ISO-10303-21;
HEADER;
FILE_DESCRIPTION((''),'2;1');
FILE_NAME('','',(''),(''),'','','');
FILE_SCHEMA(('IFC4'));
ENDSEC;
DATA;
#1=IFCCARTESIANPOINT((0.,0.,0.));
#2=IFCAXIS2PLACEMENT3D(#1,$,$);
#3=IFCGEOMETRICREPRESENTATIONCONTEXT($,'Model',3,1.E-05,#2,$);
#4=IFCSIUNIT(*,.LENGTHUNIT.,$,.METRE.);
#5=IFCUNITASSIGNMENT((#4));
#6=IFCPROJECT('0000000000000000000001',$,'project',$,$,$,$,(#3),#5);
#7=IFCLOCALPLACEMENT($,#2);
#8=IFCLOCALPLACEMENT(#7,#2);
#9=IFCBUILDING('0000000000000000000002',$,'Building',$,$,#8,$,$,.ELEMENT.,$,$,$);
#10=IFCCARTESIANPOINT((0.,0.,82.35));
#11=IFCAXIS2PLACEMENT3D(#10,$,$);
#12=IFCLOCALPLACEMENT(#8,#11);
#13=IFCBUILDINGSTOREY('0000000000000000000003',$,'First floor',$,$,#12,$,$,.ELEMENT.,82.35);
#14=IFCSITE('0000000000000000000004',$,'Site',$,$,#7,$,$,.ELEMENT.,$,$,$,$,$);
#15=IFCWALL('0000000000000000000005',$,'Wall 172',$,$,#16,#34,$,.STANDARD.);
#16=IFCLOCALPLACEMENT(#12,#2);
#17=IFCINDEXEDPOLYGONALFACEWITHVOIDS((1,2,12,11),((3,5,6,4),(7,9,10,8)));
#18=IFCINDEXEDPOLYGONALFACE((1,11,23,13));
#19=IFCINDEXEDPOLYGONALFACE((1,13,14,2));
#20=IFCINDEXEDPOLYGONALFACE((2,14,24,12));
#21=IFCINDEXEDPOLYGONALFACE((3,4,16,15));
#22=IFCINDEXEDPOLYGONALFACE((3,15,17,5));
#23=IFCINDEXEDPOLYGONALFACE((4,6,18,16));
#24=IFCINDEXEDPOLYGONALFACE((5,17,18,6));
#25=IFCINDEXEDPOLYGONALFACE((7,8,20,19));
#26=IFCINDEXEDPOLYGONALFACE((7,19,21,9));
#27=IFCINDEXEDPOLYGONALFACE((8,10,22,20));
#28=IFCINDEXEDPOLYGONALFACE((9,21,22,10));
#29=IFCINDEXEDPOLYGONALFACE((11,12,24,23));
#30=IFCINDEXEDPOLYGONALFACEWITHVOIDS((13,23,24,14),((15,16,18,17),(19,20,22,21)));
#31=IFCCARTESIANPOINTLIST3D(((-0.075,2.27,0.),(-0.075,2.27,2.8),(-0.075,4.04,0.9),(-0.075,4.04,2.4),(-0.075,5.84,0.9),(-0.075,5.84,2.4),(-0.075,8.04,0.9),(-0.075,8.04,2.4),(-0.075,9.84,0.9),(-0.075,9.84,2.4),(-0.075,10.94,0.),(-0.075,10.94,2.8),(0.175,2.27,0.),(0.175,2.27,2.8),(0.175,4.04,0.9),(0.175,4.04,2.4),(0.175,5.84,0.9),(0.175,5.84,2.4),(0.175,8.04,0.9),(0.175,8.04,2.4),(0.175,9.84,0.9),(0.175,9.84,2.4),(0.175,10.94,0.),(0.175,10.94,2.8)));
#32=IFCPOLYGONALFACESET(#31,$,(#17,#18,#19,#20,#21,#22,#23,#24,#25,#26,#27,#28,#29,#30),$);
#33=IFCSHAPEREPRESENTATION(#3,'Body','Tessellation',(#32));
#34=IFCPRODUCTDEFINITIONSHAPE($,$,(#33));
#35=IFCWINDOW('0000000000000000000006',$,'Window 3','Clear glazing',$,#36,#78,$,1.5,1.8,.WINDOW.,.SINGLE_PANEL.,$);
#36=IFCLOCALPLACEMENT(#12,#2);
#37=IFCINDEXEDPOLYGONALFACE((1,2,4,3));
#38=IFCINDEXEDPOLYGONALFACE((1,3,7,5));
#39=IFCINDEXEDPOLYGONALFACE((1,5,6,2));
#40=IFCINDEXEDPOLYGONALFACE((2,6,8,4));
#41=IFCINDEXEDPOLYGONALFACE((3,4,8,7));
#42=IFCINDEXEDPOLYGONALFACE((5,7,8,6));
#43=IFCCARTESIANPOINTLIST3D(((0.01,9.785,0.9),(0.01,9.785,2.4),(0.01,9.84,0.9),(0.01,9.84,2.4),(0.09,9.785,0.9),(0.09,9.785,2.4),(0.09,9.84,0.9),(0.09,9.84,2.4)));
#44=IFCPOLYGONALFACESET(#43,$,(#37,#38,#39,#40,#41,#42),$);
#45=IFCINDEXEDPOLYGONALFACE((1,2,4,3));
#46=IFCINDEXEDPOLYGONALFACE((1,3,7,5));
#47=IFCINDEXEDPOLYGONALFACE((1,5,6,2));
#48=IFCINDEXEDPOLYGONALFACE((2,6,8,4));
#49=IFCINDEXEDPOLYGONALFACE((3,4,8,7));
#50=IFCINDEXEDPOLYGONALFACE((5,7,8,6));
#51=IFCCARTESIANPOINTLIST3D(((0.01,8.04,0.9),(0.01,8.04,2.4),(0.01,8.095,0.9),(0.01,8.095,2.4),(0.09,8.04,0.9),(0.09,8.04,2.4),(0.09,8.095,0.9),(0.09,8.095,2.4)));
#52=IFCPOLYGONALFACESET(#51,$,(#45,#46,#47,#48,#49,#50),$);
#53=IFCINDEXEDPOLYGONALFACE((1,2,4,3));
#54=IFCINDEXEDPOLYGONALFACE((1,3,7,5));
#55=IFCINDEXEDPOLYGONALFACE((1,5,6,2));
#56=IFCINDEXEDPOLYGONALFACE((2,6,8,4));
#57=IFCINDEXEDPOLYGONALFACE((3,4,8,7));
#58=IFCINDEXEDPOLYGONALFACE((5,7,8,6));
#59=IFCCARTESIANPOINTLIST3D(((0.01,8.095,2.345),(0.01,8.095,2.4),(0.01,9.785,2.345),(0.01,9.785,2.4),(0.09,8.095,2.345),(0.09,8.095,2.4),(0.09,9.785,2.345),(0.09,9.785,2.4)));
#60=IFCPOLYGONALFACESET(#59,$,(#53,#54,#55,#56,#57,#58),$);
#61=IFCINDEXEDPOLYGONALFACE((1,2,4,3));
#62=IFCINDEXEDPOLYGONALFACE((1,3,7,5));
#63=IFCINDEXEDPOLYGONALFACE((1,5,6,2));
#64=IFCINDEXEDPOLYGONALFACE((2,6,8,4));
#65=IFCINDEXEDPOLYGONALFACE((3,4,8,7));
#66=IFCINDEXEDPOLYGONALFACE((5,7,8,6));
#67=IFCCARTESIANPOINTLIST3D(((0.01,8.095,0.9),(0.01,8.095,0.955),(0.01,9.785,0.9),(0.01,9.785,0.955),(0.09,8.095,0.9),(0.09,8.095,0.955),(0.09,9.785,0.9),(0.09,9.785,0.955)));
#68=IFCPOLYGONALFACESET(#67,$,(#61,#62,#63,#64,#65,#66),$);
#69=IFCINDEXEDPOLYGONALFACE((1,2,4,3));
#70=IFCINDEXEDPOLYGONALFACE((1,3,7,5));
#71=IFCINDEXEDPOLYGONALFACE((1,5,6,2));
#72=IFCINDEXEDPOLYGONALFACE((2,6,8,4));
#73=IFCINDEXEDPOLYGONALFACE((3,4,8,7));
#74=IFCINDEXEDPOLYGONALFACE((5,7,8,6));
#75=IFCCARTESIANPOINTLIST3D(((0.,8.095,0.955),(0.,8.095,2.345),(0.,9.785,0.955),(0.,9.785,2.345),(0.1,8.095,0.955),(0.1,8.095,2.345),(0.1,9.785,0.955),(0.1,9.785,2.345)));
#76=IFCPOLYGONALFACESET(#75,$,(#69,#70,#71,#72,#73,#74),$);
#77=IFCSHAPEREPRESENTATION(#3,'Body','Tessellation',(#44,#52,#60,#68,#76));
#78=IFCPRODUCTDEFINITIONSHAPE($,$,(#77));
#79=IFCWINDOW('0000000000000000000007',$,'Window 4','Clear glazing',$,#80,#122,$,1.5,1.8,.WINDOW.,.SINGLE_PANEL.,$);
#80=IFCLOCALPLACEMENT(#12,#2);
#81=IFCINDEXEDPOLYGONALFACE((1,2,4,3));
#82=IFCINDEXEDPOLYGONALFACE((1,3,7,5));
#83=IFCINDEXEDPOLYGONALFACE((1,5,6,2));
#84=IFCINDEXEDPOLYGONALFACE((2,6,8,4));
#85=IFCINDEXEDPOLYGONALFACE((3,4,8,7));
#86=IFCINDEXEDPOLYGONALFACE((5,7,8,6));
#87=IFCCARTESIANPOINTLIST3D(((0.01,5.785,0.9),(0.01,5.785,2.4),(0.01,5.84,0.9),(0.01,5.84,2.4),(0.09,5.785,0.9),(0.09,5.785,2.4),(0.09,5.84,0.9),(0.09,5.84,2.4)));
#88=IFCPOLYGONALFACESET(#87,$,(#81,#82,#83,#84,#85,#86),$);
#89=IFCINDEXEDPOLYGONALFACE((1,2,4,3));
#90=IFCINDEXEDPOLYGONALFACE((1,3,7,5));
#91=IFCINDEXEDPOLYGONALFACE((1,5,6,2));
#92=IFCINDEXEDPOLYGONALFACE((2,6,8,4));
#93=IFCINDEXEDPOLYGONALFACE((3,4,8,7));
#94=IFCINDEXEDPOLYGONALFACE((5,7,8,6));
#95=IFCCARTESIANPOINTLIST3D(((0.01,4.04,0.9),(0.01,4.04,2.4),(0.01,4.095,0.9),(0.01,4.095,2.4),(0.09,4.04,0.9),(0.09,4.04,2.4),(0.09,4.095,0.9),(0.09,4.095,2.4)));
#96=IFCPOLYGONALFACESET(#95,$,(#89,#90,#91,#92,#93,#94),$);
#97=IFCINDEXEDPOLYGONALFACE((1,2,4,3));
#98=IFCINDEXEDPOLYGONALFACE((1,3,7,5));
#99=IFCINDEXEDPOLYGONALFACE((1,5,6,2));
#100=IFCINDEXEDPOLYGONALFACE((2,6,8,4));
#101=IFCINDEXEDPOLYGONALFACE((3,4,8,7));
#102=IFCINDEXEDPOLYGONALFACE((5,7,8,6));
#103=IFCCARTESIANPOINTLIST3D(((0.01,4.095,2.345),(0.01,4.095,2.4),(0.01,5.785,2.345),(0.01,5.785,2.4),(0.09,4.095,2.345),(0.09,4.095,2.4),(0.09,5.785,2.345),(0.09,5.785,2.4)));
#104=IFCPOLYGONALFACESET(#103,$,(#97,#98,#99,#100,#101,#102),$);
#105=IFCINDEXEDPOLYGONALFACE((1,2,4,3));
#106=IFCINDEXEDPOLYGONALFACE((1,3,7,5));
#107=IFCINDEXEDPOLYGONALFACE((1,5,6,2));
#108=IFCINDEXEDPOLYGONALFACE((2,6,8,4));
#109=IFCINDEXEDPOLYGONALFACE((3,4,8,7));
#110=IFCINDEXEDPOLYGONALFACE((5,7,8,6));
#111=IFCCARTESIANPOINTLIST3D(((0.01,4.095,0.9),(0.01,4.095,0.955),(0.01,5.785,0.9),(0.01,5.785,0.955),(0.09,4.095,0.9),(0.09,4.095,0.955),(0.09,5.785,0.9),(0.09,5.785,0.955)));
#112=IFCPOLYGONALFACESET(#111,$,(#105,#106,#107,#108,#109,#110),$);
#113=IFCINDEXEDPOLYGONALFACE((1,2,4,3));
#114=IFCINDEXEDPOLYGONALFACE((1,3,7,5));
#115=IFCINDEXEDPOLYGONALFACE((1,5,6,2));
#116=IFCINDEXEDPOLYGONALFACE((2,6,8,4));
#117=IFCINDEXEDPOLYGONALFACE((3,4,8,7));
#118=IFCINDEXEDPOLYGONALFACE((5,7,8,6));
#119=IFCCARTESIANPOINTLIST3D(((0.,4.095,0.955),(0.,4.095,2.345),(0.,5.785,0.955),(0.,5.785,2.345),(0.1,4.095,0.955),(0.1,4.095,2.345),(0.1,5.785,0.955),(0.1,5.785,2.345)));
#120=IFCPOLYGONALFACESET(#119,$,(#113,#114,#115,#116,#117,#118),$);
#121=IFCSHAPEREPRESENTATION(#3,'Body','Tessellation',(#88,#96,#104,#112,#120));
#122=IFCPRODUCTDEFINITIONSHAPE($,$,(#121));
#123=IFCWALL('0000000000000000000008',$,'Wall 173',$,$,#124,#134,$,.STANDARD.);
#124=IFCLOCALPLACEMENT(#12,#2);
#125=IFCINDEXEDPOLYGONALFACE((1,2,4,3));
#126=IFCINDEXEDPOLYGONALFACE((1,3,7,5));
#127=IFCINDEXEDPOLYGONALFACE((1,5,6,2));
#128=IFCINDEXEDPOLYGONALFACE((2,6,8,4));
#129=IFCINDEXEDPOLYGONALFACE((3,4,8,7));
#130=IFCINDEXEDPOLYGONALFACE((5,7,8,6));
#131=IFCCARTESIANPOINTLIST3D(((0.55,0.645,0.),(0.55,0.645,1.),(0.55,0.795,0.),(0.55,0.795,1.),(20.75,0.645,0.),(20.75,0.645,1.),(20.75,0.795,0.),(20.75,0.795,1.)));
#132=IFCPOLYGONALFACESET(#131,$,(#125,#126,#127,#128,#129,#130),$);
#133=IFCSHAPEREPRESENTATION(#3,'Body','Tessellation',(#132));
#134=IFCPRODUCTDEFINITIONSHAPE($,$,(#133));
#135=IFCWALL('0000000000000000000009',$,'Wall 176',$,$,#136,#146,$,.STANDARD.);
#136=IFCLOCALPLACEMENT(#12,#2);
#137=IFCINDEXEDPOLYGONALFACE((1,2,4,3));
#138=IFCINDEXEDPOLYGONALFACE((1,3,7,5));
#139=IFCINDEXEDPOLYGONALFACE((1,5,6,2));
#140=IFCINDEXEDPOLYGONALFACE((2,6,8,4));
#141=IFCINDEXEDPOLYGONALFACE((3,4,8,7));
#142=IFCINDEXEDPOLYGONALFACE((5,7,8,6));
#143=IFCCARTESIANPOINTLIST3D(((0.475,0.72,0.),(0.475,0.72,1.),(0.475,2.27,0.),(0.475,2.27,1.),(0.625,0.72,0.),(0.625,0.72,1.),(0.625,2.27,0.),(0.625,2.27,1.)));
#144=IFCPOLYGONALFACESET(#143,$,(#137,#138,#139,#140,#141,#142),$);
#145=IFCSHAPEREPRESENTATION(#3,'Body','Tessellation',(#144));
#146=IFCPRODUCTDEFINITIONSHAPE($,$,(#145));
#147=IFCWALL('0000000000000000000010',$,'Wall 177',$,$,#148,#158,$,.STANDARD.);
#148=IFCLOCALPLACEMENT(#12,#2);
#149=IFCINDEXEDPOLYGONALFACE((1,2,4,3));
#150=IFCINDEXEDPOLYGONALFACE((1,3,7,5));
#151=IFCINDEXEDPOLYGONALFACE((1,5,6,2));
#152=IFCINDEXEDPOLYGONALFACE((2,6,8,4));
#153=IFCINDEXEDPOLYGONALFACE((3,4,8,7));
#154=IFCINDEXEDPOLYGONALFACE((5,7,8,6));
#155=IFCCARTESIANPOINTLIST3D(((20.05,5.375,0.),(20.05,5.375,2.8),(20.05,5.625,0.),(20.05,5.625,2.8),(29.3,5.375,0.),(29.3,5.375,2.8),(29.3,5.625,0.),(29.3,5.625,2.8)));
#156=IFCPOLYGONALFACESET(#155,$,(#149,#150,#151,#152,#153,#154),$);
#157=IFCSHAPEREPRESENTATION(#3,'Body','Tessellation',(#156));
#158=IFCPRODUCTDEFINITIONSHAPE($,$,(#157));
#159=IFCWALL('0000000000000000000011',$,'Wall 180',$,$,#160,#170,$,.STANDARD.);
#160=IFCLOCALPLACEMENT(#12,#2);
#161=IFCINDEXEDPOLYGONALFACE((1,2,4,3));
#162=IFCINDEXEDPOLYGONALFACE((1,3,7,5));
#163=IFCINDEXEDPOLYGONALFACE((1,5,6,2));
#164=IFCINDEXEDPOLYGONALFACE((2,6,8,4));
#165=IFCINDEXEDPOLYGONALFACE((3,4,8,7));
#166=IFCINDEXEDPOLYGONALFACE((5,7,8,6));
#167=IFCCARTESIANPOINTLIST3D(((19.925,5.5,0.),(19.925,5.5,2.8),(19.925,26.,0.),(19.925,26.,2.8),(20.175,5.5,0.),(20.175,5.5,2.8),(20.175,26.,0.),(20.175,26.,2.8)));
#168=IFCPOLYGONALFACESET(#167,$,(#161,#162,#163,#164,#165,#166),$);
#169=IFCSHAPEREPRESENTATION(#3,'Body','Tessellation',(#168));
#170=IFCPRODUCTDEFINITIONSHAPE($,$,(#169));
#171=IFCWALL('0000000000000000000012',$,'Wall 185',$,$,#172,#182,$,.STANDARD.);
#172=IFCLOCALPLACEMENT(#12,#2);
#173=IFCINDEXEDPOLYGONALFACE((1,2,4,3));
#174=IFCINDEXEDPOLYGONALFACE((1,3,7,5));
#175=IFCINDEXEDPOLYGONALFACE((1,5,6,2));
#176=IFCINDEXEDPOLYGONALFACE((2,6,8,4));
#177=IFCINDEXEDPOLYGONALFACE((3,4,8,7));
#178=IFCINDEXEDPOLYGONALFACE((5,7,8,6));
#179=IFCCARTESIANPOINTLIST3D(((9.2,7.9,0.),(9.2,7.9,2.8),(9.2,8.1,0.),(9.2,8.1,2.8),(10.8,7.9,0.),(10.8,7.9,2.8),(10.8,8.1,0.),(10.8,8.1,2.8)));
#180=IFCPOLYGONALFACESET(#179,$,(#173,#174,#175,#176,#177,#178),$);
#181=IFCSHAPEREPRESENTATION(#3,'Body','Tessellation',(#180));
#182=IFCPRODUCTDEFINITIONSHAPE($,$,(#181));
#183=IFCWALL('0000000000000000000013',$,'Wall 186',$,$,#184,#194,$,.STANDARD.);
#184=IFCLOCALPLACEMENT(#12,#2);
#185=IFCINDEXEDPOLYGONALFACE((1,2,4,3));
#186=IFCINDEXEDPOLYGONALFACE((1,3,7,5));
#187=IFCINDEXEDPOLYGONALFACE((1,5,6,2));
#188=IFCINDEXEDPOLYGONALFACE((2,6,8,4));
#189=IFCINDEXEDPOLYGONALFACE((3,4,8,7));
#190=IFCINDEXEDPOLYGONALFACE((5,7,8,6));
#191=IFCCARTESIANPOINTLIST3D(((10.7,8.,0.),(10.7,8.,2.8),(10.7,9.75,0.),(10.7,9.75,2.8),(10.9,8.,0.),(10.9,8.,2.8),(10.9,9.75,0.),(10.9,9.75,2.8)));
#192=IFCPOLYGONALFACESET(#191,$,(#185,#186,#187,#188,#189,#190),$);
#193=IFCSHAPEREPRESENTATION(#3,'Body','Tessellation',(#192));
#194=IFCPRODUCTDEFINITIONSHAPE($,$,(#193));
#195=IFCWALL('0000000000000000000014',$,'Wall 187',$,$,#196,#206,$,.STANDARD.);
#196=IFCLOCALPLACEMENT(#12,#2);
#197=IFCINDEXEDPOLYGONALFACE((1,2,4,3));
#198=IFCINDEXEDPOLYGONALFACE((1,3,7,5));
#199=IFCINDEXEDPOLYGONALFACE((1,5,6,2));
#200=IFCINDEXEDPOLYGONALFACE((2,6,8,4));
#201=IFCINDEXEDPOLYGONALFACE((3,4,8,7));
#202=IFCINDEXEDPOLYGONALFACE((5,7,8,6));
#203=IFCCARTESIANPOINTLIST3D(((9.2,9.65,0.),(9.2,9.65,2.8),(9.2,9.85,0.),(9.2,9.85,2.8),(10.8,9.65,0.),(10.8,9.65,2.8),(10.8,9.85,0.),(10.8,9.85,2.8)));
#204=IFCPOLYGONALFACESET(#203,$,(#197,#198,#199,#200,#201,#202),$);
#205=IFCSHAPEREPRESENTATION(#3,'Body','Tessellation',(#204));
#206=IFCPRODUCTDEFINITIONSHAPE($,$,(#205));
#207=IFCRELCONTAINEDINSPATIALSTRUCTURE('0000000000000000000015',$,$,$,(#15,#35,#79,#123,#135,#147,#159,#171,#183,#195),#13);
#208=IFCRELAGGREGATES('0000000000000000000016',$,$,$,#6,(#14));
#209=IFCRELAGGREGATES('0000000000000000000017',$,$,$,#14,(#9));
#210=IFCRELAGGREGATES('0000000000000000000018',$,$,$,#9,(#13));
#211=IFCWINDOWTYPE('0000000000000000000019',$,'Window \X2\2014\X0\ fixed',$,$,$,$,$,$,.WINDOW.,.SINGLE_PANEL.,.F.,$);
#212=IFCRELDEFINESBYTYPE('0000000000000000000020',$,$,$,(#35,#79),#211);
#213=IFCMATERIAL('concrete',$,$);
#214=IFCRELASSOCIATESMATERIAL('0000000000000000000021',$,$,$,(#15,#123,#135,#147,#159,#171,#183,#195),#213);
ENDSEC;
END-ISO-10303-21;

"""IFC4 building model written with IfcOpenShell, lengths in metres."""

from ifc_helpers import new_model, si_unit, frame, frame_2d, origin, place, context, project, spatial, rectangle, extrude, material, type_object, element, fill, save


model = new_model("IFC4")

# Units and contexts
model_context = context("Model", 3, precision=1e-05, world=origin())
ifc_project = project(units=[si_unit("LENGTHUNIT", "METRE")], contexts=[model_context])

# Site, building, storey
site_placement = place(None, origin())
site = spatial("IfcSite", under=ifc_project, at=site_placement, Name="Site", CompositionType="ELEMENT")
building_placement = place(site_placement, origin())
building = spatial("IfcBuilding", under=site, at=building_placement, Name="Building", CompositionType="ELEMENT")
storey_placement = place(building_placement, frame((0.0, 0.0, 82.35)))
storey = spatial("IfcBuildingStorey", under=building, at=storey_placement, Name="First floor", CompositionType="ELEMENT", Elevation=82.35)

# Shared definitions
ifc_material = material(Name="concrete")

# Shared definitions
window_type = type_object("IfcWindowType", Name="Window — fixed", ParameterTakesPrecedence=False, PartitioningType="SINGLE_PANEL", PredefinedType="WINDOW")

# Wall, openings, windows
wall_1_placement = place(storey_placement, frame((0.05, 10.94, 0.0), z_axis=(0.0, 0.0, 1.0), x_axis=(0.0, -1.0, 0.0)))
wall_1 = element("IfcWall", 1, at=wall_1_placement, inside=storey, material=ifc_material, Name="Wall 172", PredefinedType="STANDARD", context=model_context, shape_type="SweptSolid", body=[
    extrude(rectangle(XDim=8.67, YDim=0.25, at=frame_2d((4.335, 0.0))), origin(), (0.0, 0.0, 1.0), 2.8),
])
opening_1_placement = place(storey_placement, frame((0.05, 9.84, 0.9), z_axis=(0.0, 0.0, 1.0), x_axis=(0.0, -1.0, 0.0)))
opening_1 = element("IfcOpeningElement", 2, at=opening_1_placement, cuts=wall_1, PredefinedType="OPENING", context=model_context, shape_type="SweptSolid", body=[
    extrude(rectangle(XDim=1.8, YDim=0.31, at=frame_2d((0.9, 0.0))), origin(), (0.0, 0.0, 1.0), 1.5),
])
opening_2_placement = place(storey_placement, frame((0.05, 5.84, 0.9), z_axis=(0.0, 0.0, 1.0), x_axis=(0.0, -1.0, 0.0)))
opening_2 = element("IfcOpeningElement", 3, at=opening_2_placement, cuts=wall_1, PredefinedType="OPENING", context=model_context, shape_type="SweptSolid", body=[
    extrude(rectangle(XDim=1.8, YDim=0.31, at=frame_2d((0.9, 0.0))), origin(), (0.0, 0.0, 1.0), 1.5),
])
window_1_placement = place(storey_placement, frame((0.05, 9.84, 0.9), z_axis=(0.0, 0.0, 1.0), x_axis=(0.0, -1.0, 0.0)))
window_1 = element("IfcWindow", 4, at=window_1_placement, inside=storey, type_object=window_type, Name="Window 3", Description="Clear glazing", OverallHeight=1.5, OverallWidth=1.8, PartitioningType="SINGLE_PANEL", PredefinedType="WINDOW", context=model_context, shape_type="SweptSolid", body=[
    extrude(rectangle(XDim=0.055, YDim=0.08, at=frame_2d((0.0275, 0.0))), origin(), (0.0, 0.0, 1.0), 1.5),
    extrude(rectangle(XDim=0.055, YDim=0.08, at=frame_2d((1.7725, 0.0))), origin(), (0.0, 0.0, 1.0), 1.5),
    extrude(rectangle(XDim=1.69, YDim=0.08, at=frame_2d((0.9, 0.0))), frame((0.0, 0.0, 1.445)), (0.0, 0.0, 1.0), 0.055),
    extrude(rectangle(XDim=1.69, YDim=0.08, at=frame_2d((0.9, 0.0))), origin(), (0.0, 0.0, 1.0), 0.055),
    extrude(rectangle(XDim=1.69, YDim=0.1, at=frame_2d((0.9, 0.0))), frame((0.0, 0.0, 0.055)), (0.0, 0.0, 1.0), 1.39),
])
fill(opening_1, window_1)
window_2_placement = place(storey_placement, frame((0.05, 5.84, 0.9), z_axis=(0.0, 0.0, 1.0), x_axis=(0.0, -1.0, 0.0)))
window_2 = element("IfcWindow", 5, at=window_2_placement, inside=storey, type_object=window_type, Name="Window 4", Description="Clear glazing", OverallHeight=1.5, OverallWidth=1.8, PartitioningType="SINGLE_PANEL", PredefinedType="WINDOW", context=model_context, shape_type="SweptSolid", body=[
    extrude(rectangle(XDim=0.055, YDim=0.08, at=frame_2d((0.0275, 0.0))), origin(), (0.0, 0.0, 1.0), 1.5),
    extrude(rectangle(XDim=0.055, YDim=0.08, at=frame_2d((1.7725, 0.0))), origin(), (0.0, 0.0, 1.0), 1.5),
    extrude(rectangle(XDim=1.69, YDim=0.08, at=frame_2d((0.9, 0.0))), frame((0.0, 0.0, 1.445)), (0.0, 0.0, 1.0), 0.055),
    extrude(rectangle(XDim=1.69, YDim=0.08, at=frame_2d((0.9, 0.0))), origin(), (0.0, 0.0, 1.0), 0.055),
    extrude(rectangle(XDim=1.69, YDim=0.1, at=frame_2d((0.9, 0.0))), frame((0.0, 0.0, 0.055)), (0.0, 0.0, 1.0), 1.39),
])
fill(opening_2, window_2)

# Walls
wall_2_placement = place(storey_placement, frame((0.55, 0.72, 0.0), z_axis=(0.0, 0.0, 1.0), x_axis=(1.0, 0.0, 0.0)))
element("IfcWall", 6, at=wall_2_placement, inside=storey, material=ifc_material, Name="Wall 173", PredefinedType="STANDARD", context=model_context, shape_type="SweptSolid", body=[
    extrude(rectangle(XDim=20.2, YDim=0.15, at=frame_2d((10.1, 0.0))), origin(), (0.0, 0.0, 1.0), 1.0),
])
wall_3_placement = place(storey_placement, frame((0.55, 2.27, 0.0), z_axis=(0.0, 0.0, 1.0), x_axis=(0.0, -1.0, 0.0)))
element("IfcWall", 7, at=wall_3_placement, inside=storey, material=ifc_material, Name="Wall 176", PredefinedType="STANDARD", context=model_context, shape_type="SweptSolid", body=[
    extrude(rectangle(XDim=1.55, YDim=0.15, at=frame_2d((0.775, 0.0))), origin(), (0.0, 0.0, 1.0), 1.0),
])
wall_4_placement = place(storey_placement, frame((20.05, 5.5, 0.0), z_axis=(0.0, 0.0, 1.0), x_axis=(1.0, 0.0, 0.0)))
element("IfcWall", 8, at=wall_4_placement, inside=storey, material=ifc_material, Name="Wall 177", PredefinedType="STANDARD", context=model_context, shape_type="SweptSolid", body=[
    extrude(rectangle(XDim=9.25, YDim=0.25, at=frame_2d((4.625, 0.0))), origin(), (0.0, 0.0, 1.0), 2.8),
])
wall_5_placement = place(storey_placement, frame((20.05, 26.0, 0.0), z_axis=(0.0, 0.0, 1.0), x_axis=(0.0, -1.0, 0.0)))
element("IfcWall", 9, at=wall_5_placement, inside=storey, material=ifc_material, Name="Wall 180", PredefinedType="STANDARD", context=model_context, shape_type="SweptSolid", body=[
    extrude(rectangle(XDim=20.5, YDim=0.25, at=frame_2d((10.25, 0.0))), origin(), (0.0, 0.0, 1.0), 2.8),
])
wall_6_placement = place(storey_placement, frame((9.2, 8.0, 0.0), z_axis=(0.0, 0.0, 1.0), x_axis=(1.0, 0.0, 0.0)))
element("IfcWall", 10, at=wall_6_placement, inside=storey, material=ifc_material, Name="Wall 185", PredefinedType="STANDARD", context=model_context, shape_type="SweptSolid", body=[
    extrude(rectangle(XDim=1.6, YDim=0.2, at=frame_2d((0.8, 0.0))), origin(), (0.0, 0.0, 1.0), 2.8),
])
wall_7_placement = place(storey_placement, frame((10.8, 8.0, 0.0), z_axis=(0.0, 0.0, 1.0), x_axis=(0.0, 1.0, 0.0)))
element("IfcWall", 11, at=wall_7_placement, inside=storey, material=ifc_material, Name="Wall 186", PredefinedType="STANDARD", context=model_context, shape_type="SweptSolid", body=[
    extrude(rectangle(XDim=1.75, YDim=0.2, at=frame_2d((0.875, 0.0))), origin(), (0.0, 0.0, 1.0), 2.8),
])
wall_8_placement = place(storey_placement, frame((10.8, 9.75, 0.0), z_axis=(0.0, 0.0, 1.0), x_axis=(-1.0, 0.0, 0.0)))
element("IfcWall", 12, at=wall_8_placement, inside=storey, material=ifc_material, Name="Wall 187", PredefinedType="STANDARD", context=model_context, shape_type="SweptSolid", body=[
    extrude(rectangle(XDim=1.6, YDim=0.2, at=frame_2d((0.8, 0.0))), origin(), (0.0, 0.0, 1.0), 2.8),
])

save(model, "model.ifc")
